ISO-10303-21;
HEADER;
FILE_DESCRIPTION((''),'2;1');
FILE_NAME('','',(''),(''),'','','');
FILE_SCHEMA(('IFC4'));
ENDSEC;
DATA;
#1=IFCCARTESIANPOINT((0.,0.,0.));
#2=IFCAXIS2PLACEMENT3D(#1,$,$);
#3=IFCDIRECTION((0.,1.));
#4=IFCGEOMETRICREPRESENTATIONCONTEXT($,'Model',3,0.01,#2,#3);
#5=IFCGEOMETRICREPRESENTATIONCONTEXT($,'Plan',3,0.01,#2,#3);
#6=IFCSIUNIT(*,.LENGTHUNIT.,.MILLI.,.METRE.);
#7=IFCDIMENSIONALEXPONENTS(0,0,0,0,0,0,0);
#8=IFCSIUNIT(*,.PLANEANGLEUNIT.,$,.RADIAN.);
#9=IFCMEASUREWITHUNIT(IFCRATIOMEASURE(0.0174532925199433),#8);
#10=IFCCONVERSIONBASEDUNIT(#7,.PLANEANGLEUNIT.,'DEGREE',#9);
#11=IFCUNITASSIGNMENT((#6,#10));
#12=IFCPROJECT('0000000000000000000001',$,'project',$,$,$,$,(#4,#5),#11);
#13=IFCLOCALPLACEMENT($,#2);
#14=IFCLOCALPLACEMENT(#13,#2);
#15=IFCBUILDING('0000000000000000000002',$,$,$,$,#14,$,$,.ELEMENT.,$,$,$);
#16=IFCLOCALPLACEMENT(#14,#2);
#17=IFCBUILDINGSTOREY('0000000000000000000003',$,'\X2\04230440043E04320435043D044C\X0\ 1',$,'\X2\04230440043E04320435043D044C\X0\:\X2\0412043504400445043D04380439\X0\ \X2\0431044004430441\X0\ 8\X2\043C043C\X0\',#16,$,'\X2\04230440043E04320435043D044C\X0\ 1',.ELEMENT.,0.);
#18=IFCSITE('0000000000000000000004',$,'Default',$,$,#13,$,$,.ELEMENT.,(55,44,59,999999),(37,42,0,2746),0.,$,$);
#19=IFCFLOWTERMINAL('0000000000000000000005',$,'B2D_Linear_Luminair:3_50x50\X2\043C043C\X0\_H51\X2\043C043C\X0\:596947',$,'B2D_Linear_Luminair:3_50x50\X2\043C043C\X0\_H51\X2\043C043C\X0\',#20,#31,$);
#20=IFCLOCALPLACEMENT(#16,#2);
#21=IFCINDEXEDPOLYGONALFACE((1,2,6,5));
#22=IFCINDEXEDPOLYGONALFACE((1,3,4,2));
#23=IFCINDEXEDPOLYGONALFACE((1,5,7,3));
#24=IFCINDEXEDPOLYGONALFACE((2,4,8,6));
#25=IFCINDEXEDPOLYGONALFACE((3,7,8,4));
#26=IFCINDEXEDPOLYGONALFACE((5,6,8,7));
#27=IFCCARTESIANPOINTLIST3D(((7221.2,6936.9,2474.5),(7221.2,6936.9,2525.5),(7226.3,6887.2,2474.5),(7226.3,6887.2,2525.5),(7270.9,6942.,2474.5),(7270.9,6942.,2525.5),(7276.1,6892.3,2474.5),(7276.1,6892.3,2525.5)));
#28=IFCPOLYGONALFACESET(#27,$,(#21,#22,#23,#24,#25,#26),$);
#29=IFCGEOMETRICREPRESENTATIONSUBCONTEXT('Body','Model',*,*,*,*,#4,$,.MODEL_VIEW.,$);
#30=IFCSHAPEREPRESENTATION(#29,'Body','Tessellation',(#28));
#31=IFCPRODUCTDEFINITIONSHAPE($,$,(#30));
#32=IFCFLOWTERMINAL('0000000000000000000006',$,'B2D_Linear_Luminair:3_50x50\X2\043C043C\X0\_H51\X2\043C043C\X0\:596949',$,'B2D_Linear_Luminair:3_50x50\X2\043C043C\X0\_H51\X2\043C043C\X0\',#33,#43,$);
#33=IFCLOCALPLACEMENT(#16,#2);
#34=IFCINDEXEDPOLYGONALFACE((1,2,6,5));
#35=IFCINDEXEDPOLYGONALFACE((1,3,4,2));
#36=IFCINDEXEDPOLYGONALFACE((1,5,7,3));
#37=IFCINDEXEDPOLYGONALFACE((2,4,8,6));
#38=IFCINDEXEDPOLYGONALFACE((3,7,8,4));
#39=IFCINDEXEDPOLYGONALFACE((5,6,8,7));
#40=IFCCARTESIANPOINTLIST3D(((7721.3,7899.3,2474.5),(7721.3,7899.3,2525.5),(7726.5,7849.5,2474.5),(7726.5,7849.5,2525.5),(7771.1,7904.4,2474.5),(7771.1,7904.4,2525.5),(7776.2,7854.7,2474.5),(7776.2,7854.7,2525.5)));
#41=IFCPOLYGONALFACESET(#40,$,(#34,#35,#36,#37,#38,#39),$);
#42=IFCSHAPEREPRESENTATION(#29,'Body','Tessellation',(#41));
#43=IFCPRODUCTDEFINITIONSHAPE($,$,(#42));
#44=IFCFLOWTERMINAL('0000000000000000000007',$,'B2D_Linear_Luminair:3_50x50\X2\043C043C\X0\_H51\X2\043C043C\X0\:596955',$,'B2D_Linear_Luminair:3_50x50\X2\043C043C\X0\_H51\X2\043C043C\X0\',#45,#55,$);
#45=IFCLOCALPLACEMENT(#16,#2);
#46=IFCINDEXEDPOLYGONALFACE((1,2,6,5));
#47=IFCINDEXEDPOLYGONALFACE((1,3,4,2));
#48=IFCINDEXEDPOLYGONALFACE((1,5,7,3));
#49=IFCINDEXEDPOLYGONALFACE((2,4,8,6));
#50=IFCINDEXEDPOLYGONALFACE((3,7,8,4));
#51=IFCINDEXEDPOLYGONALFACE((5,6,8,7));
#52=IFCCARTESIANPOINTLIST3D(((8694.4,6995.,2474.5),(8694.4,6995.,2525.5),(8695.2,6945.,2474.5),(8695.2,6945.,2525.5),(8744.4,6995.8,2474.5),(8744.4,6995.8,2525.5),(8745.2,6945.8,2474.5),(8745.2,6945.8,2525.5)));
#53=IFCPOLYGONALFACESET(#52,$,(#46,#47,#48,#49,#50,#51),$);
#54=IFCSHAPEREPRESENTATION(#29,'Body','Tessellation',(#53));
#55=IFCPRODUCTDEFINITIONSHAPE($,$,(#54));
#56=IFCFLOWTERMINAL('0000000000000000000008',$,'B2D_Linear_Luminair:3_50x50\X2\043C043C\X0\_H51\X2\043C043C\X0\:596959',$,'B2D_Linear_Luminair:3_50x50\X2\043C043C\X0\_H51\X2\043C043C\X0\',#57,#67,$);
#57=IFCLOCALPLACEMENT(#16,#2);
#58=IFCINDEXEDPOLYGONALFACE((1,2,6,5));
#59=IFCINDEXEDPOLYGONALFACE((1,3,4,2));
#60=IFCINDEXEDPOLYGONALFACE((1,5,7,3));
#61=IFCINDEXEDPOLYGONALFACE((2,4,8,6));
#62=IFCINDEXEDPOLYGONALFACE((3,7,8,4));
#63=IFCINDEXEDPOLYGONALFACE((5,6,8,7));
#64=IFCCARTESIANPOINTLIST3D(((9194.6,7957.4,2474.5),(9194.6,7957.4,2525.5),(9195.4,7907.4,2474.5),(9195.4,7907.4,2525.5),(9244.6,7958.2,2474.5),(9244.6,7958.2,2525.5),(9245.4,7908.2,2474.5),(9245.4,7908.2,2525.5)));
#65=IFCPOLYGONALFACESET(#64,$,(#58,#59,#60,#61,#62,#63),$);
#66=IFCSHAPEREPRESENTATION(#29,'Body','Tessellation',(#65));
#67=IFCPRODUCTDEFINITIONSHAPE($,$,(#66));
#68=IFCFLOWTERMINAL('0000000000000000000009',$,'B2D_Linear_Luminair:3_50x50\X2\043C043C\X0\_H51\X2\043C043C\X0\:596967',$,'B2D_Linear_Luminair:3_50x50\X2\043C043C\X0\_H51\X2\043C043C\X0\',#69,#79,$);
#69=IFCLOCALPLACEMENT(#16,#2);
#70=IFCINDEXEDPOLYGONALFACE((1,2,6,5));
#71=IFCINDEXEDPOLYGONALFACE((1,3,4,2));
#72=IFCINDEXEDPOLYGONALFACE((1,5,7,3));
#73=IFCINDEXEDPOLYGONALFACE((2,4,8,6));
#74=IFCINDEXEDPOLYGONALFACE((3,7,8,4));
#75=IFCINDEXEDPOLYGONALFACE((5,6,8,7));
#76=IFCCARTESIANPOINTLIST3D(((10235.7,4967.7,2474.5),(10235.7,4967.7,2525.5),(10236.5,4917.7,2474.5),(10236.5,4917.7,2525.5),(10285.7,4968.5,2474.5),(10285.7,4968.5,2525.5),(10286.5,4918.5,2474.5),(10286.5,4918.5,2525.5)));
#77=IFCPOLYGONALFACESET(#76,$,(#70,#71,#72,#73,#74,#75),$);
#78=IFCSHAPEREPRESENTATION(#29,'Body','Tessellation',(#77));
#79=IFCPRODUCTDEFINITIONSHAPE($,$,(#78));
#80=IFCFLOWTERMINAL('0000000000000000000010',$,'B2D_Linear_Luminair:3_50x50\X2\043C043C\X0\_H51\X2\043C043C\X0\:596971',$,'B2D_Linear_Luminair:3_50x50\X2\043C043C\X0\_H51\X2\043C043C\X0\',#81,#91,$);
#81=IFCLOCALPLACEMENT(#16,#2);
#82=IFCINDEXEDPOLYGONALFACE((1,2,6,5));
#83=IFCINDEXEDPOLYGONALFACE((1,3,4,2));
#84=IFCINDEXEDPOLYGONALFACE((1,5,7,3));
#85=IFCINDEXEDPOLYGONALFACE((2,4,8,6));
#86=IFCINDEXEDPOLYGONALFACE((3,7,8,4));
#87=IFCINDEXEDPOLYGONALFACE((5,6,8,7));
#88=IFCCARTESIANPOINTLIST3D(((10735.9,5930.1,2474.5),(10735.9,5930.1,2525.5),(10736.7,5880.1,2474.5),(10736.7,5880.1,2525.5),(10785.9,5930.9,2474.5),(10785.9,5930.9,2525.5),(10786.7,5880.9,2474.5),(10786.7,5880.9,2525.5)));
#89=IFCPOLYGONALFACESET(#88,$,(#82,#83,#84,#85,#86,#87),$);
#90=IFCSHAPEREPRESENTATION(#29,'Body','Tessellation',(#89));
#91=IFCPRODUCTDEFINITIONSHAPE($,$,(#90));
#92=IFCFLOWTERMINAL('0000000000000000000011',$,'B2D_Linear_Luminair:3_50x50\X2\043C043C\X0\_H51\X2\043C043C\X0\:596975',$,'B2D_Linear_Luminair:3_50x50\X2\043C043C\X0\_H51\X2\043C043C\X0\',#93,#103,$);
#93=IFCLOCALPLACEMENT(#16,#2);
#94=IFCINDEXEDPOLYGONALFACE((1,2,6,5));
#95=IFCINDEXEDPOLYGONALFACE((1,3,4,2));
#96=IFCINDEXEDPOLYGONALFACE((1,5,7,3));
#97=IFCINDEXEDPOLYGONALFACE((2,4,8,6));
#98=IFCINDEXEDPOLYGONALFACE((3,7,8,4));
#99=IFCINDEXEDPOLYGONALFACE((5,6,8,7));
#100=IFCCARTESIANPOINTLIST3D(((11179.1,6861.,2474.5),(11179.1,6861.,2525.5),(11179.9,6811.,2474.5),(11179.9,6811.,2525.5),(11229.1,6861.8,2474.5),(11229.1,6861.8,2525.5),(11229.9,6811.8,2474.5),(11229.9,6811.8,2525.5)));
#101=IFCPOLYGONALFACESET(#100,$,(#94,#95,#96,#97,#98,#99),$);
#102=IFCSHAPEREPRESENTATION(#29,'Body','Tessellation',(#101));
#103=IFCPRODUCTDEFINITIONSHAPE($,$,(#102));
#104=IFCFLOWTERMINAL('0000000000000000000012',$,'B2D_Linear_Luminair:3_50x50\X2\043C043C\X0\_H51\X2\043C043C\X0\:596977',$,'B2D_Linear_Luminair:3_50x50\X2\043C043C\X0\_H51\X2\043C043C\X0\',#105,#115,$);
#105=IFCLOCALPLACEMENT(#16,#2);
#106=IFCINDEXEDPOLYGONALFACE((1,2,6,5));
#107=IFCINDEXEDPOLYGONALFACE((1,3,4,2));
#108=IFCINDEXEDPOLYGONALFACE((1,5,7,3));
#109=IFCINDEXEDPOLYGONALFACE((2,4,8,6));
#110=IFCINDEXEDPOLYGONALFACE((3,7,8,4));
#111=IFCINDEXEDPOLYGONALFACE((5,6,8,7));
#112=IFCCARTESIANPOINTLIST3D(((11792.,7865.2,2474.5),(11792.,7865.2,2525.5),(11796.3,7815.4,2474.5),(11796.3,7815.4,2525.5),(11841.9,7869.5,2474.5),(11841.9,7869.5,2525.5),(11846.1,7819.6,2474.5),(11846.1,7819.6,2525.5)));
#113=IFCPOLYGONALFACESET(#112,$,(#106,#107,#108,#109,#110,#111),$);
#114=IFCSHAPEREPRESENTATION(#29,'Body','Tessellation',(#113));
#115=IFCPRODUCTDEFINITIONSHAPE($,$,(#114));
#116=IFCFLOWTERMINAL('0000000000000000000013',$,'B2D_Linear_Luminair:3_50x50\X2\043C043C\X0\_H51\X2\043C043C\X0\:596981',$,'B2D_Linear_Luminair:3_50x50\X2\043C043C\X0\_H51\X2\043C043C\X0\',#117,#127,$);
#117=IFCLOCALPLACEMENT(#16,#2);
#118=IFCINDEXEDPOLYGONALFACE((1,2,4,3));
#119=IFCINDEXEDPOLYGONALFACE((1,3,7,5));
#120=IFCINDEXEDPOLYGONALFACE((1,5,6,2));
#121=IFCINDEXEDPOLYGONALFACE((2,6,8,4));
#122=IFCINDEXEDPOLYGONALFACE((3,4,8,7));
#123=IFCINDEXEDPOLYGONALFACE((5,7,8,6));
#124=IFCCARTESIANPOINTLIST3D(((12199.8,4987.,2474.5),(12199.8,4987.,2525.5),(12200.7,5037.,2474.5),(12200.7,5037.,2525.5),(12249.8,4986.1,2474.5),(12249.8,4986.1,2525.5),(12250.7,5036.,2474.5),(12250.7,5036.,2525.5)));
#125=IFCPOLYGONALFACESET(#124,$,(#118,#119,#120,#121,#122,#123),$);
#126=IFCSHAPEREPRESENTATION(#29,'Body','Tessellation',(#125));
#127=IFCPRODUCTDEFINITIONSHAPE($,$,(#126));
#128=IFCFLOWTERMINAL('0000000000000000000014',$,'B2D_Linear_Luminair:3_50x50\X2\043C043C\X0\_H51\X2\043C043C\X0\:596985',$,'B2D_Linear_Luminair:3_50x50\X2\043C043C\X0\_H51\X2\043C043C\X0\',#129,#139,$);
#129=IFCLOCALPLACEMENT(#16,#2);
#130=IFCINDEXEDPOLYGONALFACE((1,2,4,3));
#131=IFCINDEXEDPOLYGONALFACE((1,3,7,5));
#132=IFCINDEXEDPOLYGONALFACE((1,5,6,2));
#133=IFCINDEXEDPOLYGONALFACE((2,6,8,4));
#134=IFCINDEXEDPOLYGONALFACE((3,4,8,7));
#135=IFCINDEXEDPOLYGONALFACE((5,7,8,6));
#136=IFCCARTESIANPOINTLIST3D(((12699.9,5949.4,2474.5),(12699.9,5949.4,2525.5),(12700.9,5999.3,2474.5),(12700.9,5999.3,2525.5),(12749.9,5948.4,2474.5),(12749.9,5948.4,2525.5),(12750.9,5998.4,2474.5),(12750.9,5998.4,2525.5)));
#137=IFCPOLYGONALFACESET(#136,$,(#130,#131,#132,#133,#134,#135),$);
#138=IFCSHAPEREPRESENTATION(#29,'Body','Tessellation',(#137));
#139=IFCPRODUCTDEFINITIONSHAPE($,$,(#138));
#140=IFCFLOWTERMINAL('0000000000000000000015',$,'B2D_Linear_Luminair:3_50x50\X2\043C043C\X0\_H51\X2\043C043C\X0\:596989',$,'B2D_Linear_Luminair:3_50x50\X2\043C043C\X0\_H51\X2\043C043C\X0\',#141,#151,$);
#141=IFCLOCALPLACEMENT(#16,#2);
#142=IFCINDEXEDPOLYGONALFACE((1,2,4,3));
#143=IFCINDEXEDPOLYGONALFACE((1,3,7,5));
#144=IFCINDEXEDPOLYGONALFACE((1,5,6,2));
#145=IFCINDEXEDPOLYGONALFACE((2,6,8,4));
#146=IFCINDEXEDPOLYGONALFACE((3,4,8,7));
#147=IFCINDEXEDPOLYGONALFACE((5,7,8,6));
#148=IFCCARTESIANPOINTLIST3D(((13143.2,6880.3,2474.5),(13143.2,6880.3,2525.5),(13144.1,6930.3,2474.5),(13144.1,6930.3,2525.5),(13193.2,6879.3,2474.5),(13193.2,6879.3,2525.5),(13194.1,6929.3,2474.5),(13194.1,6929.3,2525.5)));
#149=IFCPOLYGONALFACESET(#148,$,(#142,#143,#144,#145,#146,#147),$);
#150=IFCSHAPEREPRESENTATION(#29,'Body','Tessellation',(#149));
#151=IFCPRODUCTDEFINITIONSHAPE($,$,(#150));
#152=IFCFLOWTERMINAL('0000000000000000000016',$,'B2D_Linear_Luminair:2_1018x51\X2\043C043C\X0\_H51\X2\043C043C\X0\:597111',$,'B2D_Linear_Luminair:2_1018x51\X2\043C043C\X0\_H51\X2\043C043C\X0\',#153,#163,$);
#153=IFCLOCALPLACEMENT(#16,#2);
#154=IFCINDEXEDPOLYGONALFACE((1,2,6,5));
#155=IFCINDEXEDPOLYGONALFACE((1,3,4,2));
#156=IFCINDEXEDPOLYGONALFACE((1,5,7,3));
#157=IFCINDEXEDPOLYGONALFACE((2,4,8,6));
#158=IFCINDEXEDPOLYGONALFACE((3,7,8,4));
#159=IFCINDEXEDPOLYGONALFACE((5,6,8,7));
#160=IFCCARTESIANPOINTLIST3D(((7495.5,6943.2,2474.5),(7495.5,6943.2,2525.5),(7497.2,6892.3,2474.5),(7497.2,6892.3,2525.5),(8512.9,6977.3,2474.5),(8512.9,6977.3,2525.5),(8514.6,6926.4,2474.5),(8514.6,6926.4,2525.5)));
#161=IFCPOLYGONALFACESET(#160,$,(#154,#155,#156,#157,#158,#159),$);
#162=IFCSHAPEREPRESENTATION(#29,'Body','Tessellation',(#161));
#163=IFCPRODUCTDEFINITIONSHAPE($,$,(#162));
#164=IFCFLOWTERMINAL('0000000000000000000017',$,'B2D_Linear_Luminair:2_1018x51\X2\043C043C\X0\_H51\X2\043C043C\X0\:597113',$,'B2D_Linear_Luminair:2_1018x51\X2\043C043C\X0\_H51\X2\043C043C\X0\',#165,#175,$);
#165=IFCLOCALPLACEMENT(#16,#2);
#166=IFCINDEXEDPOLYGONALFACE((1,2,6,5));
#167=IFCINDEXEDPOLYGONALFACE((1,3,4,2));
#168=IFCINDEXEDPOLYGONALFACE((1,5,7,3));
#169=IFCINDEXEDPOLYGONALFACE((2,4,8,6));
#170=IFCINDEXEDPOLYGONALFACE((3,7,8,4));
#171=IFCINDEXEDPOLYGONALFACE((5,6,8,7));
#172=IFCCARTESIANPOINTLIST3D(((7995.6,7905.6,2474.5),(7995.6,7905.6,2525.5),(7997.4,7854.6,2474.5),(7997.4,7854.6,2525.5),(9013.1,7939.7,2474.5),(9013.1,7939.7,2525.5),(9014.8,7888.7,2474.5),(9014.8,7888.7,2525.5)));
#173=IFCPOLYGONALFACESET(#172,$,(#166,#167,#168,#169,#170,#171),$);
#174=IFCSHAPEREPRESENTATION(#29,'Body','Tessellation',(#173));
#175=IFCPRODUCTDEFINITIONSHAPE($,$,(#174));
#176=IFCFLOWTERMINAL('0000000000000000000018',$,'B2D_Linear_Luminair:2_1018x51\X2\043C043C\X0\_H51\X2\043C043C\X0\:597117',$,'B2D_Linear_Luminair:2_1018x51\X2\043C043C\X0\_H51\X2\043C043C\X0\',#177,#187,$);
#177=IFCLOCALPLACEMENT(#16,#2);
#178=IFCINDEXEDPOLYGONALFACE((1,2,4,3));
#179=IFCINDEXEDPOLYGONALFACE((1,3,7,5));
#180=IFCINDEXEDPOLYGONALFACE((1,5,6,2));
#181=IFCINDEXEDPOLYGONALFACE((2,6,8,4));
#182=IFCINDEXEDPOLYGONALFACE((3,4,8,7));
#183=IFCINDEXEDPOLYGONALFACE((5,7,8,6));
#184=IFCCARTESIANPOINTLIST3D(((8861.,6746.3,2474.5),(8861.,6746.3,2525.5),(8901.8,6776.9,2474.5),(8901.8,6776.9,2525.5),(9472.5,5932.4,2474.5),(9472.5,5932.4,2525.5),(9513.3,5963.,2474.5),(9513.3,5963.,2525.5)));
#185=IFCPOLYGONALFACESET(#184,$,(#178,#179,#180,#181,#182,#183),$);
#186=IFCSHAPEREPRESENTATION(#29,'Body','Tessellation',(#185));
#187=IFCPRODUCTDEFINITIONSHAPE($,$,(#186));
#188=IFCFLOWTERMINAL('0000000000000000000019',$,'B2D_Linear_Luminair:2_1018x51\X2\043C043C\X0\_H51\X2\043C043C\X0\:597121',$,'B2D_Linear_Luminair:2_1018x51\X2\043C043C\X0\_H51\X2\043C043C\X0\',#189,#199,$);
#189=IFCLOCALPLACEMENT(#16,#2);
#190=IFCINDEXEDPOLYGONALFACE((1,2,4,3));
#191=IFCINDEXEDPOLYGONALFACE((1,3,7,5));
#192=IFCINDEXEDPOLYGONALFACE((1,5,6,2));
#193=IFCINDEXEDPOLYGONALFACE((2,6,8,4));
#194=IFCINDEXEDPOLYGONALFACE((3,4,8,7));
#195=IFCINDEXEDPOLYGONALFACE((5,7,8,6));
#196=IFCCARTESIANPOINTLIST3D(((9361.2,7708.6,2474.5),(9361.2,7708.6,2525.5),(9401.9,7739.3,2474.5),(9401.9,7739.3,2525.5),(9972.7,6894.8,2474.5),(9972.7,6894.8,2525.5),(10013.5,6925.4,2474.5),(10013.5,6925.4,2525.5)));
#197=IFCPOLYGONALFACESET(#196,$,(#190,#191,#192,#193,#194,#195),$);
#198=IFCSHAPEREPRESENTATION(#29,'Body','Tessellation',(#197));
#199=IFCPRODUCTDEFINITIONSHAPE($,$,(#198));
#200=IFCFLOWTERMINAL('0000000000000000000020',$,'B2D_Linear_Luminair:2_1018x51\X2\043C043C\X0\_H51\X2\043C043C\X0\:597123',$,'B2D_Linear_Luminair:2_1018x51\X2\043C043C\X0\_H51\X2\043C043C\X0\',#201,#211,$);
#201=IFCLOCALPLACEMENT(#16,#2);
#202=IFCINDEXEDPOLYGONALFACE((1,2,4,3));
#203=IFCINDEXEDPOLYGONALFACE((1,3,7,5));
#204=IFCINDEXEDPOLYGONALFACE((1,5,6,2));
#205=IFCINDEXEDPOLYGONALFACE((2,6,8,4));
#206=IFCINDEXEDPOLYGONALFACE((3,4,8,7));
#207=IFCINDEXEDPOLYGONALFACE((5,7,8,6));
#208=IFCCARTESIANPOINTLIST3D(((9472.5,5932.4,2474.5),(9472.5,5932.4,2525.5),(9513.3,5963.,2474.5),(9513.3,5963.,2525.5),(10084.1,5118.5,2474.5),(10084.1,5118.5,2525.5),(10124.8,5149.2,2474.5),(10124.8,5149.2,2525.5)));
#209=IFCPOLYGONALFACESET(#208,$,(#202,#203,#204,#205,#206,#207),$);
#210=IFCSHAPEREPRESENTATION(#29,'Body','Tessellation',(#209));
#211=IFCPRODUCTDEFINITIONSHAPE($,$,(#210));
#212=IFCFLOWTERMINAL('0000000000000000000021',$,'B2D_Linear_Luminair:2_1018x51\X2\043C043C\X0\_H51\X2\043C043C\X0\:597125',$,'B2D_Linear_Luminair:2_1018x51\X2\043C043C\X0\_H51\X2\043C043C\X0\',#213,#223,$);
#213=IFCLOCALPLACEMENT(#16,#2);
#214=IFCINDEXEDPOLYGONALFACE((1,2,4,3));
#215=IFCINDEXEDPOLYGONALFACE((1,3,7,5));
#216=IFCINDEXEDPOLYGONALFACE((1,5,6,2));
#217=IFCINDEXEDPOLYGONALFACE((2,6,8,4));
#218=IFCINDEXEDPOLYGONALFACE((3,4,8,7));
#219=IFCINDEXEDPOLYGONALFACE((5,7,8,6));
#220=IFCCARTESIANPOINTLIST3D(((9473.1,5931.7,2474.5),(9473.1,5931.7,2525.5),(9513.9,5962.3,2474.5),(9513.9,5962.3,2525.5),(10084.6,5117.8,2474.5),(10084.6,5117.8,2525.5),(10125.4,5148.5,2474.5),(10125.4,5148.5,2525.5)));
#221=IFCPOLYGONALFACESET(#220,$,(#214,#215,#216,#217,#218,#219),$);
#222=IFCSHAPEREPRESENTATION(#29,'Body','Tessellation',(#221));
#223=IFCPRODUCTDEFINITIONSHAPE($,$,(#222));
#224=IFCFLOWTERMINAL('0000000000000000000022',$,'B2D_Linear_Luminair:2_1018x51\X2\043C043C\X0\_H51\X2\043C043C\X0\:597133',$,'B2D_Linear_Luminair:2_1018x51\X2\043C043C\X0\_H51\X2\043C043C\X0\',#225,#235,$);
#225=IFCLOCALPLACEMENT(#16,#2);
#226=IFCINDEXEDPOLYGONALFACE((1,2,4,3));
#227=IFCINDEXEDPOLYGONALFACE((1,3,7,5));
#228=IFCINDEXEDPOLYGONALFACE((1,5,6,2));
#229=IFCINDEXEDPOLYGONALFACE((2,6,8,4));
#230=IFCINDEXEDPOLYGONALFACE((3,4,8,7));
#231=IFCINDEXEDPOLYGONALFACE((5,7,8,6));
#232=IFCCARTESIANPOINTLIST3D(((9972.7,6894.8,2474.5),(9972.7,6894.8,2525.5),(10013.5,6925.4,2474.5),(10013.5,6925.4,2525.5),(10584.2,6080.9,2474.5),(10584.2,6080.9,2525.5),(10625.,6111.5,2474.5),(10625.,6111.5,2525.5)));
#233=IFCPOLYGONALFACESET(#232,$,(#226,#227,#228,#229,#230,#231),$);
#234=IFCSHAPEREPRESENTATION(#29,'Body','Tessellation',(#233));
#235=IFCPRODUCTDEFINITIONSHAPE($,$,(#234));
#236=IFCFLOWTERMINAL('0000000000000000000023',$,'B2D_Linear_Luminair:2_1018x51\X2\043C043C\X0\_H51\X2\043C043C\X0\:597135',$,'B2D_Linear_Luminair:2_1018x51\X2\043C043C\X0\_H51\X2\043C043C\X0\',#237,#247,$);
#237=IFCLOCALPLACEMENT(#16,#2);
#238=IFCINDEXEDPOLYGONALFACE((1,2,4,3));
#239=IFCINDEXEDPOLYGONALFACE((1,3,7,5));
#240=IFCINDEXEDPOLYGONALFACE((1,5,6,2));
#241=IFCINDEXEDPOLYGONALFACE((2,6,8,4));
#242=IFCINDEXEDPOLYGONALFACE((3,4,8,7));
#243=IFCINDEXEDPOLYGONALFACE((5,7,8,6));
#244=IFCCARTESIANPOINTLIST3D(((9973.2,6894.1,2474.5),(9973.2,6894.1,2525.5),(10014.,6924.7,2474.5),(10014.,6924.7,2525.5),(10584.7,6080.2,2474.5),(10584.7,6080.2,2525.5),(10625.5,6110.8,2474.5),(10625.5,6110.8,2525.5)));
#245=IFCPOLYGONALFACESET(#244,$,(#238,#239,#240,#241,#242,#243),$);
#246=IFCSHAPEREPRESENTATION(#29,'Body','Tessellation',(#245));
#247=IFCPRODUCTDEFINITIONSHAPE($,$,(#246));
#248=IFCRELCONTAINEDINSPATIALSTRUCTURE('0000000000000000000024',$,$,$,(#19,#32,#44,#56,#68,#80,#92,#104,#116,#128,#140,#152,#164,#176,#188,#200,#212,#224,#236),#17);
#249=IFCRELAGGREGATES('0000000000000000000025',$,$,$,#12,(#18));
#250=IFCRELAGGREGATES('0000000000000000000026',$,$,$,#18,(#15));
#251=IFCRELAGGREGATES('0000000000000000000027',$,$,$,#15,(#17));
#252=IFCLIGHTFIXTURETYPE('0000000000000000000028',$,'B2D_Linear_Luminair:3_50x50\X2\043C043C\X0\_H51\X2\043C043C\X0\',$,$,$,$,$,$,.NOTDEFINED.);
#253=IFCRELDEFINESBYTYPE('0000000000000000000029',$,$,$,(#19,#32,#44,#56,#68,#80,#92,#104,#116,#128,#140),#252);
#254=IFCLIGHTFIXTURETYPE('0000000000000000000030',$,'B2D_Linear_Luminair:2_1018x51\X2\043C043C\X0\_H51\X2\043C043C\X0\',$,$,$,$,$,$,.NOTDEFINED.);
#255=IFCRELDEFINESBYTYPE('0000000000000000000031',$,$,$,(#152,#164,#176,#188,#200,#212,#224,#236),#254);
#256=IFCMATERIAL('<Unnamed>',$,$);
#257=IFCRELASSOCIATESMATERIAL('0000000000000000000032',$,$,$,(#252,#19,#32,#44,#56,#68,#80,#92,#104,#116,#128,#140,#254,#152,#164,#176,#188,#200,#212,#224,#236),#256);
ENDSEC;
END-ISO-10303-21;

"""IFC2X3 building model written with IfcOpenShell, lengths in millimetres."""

from ifc_helpers import new_model, entity, si_unit, converted_unit, direction, frame, origin, origin_2d_with_axis, place, context, subcontext, project, spatial, rectangle, extrude, source, transform, mapped, material, type_object, type_shapes, element, save


model = new_model("IFC2X3")

# Units and contexts
model_context = context("Model", 3, precision=0.01, world=origin(), true_north=direction((0.0, 1.0)))
plan_context = context("Plan", 3, precision=0.01, world=origin(), true_north=direction((0.0, 1.0)))
body_context = subcontext(model_context, "Body", "Model", "MODEL_VIEW")
ifc_project = project(units=[si_unit("LENGTHUNIT", "METRE", prefix="MILLI"), converted_unit("PLANEANGLEUNIT", "DEGREE", entity("IfcRatioMeasure", 0.0174532925199433), si_unit("PLANEANGLEUNIT", "RADIAN"), dimensions=[0, 0, 0, 0, 0, 0, 0])], contexts=[model_context, plan_context])

# Site, building, storey
site_placement = place(None, origin())
site = spatial("IfcSite", under=ifc_project, at=site_placement, Name="Default", CompositionType="ELEMENT", RefLatitude=(55, 44, 59, 999999), RefLongitude=(37, 42, 0, 2746), RefElevation=0.0)
building_placement = place(site_placement, origin())
building = spatial("IfcBuilding", under=site, at=building_placement, CompositionType="ELEMENT")
storey_placement = place(building_placement, origin())
storey = spatial("IfcBuildingStorey", under=building, at=storey_placement, Name="Уровень 1", ObjectType="Уровень:Верхний брус 8мм", LongName="Уровень 1", CompositionType="ELEMENT", Elevation=0.0)

# Flow terminals
ifc_material = material(Name="<Unnamed>")
light_fixture_type_1 = type_object("IfcLightFixtureType", Name="B2D_Linear_Luminair:3_50x50мм_H51мм", PredefinedType="NOTDEFINED", material=ifc_material)
shared_shape_1 = source(origin(), body_context, "Body", "SweptSolid", [
    extrude(rectangle(XDim=50.0, YDim=50.0, at=origin_2d_with_axis()), frame((0.0, 0.0, 0.0), z_axis=(0.0, 0.0, 1.0), x_axis=(-1.0, 0.0, 0.0)), (0.0, 0.0, 1.0), 51.0),
])
type_shapes(light_fixture_type_1, [shared_shape_1])
for number, where, z_axis, x_axis, name in (
    (1, (7248.6, 6914.6, 2525.5), (0.0, 0.0, -1.0), (0.994667, 0.10314, 0.0), "B2D_Linear_Luminair:3_50x50мм_H51мм:596947"),
    (2, (7748.8, 7877.0, 2525.5), (0.0, 0.0, -1.0), (0.994667, 0.10314, 0.0), "B2D_Linear_Luminair:3_50x50мм_H51мм:596949"),
    (3, (8719.8, 6970.4, 2525.5), (0.0, 0.0, -1.0), (0.999871, 0.016056, 0.0), "B2D_Linear_Luminair:3_50x50мм_H51мм:596955"),
    (4, (9220.0, 7932.8, 2525.5), (0.0, 0.0, -1.0), (0.999871, 0.016056, 0.0), "B2D_Linear_Luminair:3_50x50мм_H51мм:596959"),
    (5, (10261.1, 4943.1, 2525.5), (0.0, 0.0, -1.0), (0.999871, 0.016056, 0.0), "B2D_Linear_Luminair:3_50x50мм_H51мм:596967"),
    (6, (10761.3, 5905.5, 2525.5), (0.0, 0.0, -1.0), (0.999871, 0.016056, 0.0), "B2D_Linear_Luminair:3_50x50мм_H51мм:596971"),
    (7, (11204.5, 6836.4, 2525.5), (0.0, 0.0, -1.0), (0.999871, 0.016056, 0.0), "B2D_Linear_Luminair:3_50x50мм_H51мм:596975"),
    (8, (11819.1, 7842.4, 2525.5), (0.0, 0.0, -1.0), (0.996315, 0.085765, 0.0), "B2D_Linear_Luminair:3_50x50мм_H51мм:596977"),
    (9, (12225.2, 5011.5, 2525.5), (0.0, 0.0, -1.0), (0.018848, 0.999822, 0.0), "B2D_Linear_Luminair:3_50x50мм_H51мм:596981"),
    (10, (12725.4, 5973.9, 2525.5), (0.0, 0.0, -1.0), (0.018848, 0.999822, 0.0), "B2D_Linear_Luminair:3_50x50мм_H51мм:596985"),
    (11, (13168.6, 6904.8, 2525.5), (0.0, 0.0, -1.0), (0.018848, 0.999822, 0.0), "B2D_Linear_Luminair:3_50x50мм_H51мм:596989"),
):
    element("IfcFlowTerminal", number, at=place(storey_placement, frame(where, z_axis=z_axis, x_axis=x_axis)), inside=storey, type_object=light_fixture_type_1, material=ifc_material, Name=name, ObjectType="B2D_Linear_Luminair:3_50x50мм_H51мм", context=body_context, shape_type="MappedRepresentation", body=[
        mapped(shared_shape_1, transform((0.0, 0.0, 0.0), scale=1.0)),
    ])
light_fixture_type_2 = type_object("IfcLightFixtureType", Name="B2D_Linear_Luminair:2_1018x51мм_H51мм", PredefinedType="NOTDEFINED", material=ifc_material)
shared_shape_2 = source(origin(), body_context, "Body", "SweptSolid", [
    extrude(rectangle(XDim=1018.0, YDim=51.0, at=origin_2d_with_axis()), frame((0.0, 0.0, 0.0), z_axis=(0.0, 0.0, 1.0), x_axis=(-1.0, 0.0, 0.0)), (0.0, 0.0, 1.0), 51.0),
])
type_shapes(light_fixture_type_2, [shared_shape_2])
for number, where, z_axis, x_axis, name in (
    (12, (8005.1, 6934.8, 2525.5), (0.0, 0.0, -1.0), (0.999439, 0.033504, 0.0), "B2D_Linear_Luminair:2_1018x51мм_H51мм:597111"),
    (13, (8505.2, 7897.2, 2525.5), (0.0, 0.0, -1.0), (0.999439, 0.033504, 0.0), "B2D_Linear_Luminair:2_1018x51мм_H51мм:597113"),
    (14, (9187.2, 6354.6, 2525.5), (0.0, 0.0, -1.0), (0.600699, -0.799475, 0.0), "B2D_Linear_Luminair:2_1018x51мм_H51мм:597117"),
    (15, (9687.3, 7317.0, 2525.5), (0.0, 0.0, -1.0), (0.600699, -0.799475, 0.0), "B2D_Linear_Luminair:2_1018x51мм_H51мм:597121"),
    (16, (9798.7, 5540.8, 2525.5), (0.0, 0.0, -1.0), (0.600699, -0.799475, 0.0), "B2D_Linear_Luminair:2_1018x51мм_H51мм:597123"),
    (17, (9799.2, 5540.1, 2525.5), (0.0, 0.0, -1.0), (0.600699, -0.799475, 0.0), "B2D_Linear_Luminair:2_1018x51мм_H51мм:597125"),
    (18, (10298.8, 6503.2, 2525.5), (0.0, 0.0, -1.0), (0.600699, -0.799475, 0.0), "B2D_Linear_Luminair:2_1018x51мм_H51мм:597133"),
    (19, (10299.4, 6502.5, 2525.5), (0.0, 0.0, -1.0), (0.600699, -0.799475, 0.0), "B2D_Linear_Luminair:2_1018x51мм_H51мм:597135"),
):
    element("IfcFlowTerminal", number, at=place(storey_placement, frame(where, z_axis=z_axis, x_axis=x_axis)), inside=storey, type_object=light_fixture_type_2, material=ifc_material, Name=name, ObjectType="B2D_Linear_Luminair:2_1018x51мм_H51мм", context=body_context, shape_type="MappedRepresentation", body=[
        mapped(shared_shape_2, transform((0.0, 0.0, 0.0), scale=1.0)),
    ])

save(model, "model.ifc")
